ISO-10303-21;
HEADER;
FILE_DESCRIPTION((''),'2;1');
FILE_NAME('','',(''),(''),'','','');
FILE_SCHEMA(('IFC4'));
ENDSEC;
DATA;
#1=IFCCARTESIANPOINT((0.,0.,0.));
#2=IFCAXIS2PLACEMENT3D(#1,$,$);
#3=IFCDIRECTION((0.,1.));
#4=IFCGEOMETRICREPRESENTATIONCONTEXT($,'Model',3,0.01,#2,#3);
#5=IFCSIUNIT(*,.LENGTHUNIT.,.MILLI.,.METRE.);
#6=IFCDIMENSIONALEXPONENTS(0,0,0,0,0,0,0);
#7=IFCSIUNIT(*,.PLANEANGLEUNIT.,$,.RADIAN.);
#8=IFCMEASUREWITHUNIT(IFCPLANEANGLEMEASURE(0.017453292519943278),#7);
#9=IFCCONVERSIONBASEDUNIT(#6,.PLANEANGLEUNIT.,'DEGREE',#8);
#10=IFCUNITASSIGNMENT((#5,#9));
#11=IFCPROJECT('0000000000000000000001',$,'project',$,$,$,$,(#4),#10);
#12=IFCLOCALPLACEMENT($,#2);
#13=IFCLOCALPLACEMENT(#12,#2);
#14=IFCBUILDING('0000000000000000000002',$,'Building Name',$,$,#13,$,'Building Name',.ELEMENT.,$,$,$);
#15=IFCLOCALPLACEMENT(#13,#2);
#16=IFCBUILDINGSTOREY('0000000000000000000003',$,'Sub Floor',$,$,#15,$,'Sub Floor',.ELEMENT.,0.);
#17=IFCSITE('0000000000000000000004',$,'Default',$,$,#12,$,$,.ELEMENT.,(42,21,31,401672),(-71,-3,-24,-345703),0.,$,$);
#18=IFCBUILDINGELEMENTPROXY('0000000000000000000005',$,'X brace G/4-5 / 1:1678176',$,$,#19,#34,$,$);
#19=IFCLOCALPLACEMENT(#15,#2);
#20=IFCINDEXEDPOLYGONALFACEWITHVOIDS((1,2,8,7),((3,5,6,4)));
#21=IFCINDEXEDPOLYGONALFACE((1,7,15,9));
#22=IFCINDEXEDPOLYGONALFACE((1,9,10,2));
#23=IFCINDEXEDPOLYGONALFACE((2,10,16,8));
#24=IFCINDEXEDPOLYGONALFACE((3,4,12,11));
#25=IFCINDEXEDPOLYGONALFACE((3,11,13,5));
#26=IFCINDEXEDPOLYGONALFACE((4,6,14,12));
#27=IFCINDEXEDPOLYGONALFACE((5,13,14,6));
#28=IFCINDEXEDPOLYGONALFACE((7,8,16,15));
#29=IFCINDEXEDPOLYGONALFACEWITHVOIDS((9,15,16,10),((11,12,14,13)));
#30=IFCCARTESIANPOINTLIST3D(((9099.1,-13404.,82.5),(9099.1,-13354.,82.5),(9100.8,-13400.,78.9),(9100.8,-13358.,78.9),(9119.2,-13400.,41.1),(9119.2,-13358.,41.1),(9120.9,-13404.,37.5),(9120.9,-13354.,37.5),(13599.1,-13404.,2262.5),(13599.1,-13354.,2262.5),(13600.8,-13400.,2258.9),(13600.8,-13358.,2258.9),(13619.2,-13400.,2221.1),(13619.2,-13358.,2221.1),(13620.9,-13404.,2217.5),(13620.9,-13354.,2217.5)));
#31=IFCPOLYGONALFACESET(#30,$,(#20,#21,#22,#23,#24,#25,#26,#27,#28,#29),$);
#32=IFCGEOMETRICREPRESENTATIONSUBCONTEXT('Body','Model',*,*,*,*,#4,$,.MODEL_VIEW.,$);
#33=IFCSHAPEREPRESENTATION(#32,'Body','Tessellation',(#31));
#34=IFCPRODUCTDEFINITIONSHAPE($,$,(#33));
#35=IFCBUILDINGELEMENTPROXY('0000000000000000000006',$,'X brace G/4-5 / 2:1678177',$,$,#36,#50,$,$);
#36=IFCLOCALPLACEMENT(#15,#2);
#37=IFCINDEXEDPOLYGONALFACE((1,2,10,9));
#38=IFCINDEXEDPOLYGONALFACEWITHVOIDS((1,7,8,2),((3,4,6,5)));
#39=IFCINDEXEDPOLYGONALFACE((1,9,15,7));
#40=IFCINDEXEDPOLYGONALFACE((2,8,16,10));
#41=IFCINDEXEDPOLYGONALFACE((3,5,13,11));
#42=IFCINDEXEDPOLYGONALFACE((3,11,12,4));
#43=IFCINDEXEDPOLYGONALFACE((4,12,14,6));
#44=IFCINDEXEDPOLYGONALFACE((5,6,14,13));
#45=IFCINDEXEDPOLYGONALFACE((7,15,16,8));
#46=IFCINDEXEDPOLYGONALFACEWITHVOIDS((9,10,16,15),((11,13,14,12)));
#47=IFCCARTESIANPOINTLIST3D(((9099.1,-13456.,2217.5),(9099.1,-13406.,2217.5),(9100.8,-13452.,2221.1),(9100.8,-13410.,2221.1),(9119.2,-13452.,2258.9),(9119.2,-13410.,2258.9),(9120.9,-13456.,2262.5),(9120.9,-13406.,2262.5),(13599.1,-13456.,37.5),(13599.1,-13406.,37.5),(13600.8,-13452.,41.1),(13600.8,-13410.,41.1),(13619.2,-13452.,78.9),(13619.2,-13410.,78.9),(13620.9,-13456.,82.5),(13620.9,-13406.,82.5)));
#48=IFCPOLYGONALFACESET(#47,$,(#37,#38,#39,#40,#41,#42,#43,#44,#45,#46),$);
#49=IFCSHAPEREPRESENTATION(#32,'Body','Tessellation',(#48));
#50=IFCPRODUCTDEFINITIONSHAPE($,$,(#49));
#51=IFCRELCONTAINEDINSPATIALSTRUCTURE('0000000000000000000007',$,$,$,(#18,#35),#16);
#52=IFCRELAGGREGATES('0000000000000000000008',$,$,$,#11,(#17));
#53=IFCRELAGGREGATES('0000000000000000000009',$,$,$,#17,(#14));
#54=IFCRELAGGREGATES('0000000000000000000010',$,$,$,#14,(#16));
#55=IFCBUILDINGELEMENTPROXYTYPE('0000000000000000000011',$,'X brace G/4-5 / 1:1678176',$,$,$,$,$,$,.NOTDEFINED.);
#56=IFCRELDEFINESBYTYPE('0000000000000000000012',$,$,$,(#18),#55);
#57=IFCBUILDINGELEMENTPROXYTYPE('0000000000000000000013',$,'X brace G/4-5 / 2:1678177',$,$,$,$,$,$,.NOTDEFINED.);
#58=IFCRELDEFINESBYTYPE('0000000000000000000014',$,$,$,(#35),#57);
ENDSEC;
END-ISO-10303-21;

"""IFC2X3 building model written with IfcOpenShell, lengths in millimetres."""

from ifc_helpers import new_model, entity, si_unit, converted_unit, direction, frame, origin, place, context, subcontext, project, spatial, polyline, outline, extrude, type_object, element, save


model = new_model("IFC2X3")

# Units and contexts
model_context = context("Model", 3, precision=0.01, world=origin(), true_north=direction((0.0, 1.0)))
body_context = subcontext(model_context, "Body", "Model", "MODEL_VIEW")
ifc_project = project(units=[si_unit("LENGTHUNIT", "METRE", prefix="MILLI"), converted_unit("PLANEANGLEUNIT", "DEGREE", entity("IfcPlaneAngleMeasure", 0.017453292519943278), si_unit("PLANEANGLEUNIT", "RADIAN"), dimensions=[0, 0, 0, 0, 0, 0, 0])], contexts=[model_context])

# Site, building, storey
site_placement = place(None, origin())
site = spatial("IfcSite", under=ifc_project, at=site_placement, Name="Default", CompositionType="ELEMENT", RefLatitude=(42, 21, 31, 401672), RefLongitude=(-71, -3, -24, -345703), RefElevation=0.0)
building_placement = place(site_placement, origin())
building = spatial("IfcBuilding", under=site, at=building_placement, Name="Building Name", LongName="Building Name", CompositionType="ELEMENT")
storey_placement = place(building_placement, origin())
storey = spatial("IfcBuildingStorey", under=building, at=storey_placement, Name="Sub Floor", LongName="Sub Floor", CompositionType="ELEMENT", Elevation=0.0)

# Building element proxies
building_element_proxy_type_1 = type_object("IfcBuildingElementProxyType", Name="X brace G/4-5 / 1:1678176", PredefinedType="NOTDEFINED")
proxy_1_placement = place(storey_placement, origin())
element("IfcBuildingElementProxy", 1, at=proxy_1_placement, inside=storey, type_object=building_element_proxy_type_1, Name="X brace G/4-5 / 1:1678176", context=body_context, shape_type="SweptSolid", body=[
    extrude(outline(polyline([(-25.0, -25.0), (25.0, -25.0), (25.0, 25.0), (-25.0, 25.0), (-25.0, -25.0)]), holes=[polyline([(-21.0, -21.0), (-21.0, 21.0), (21.0, 21.0), (21.0, -21.0), (-21.0, -21.0)])]), frame((9110.0, -13379.0, 60.0), z_axis=(0.899957, 0.0, 0.435979), x_axis=(0.0, -1.0, 0.0)), (0.0, 0.0, 1.0), 5000.2),
])
building_element_proxy_type_2 = type_object("IfcBuildingElementProxyType", Name="X brace G/4-5 / 2:1678177", PredefinedType="NOTDEFINED")
proxy_2_placement = place(storey_placement, origin())
element("IfcBuildingElementProxy", 2, at=proxy_2_placement, inside=storey, type_object=building_element_proxy_type_2, Name="X brace G/4-5 / 2:1678177", context=body_context, shape_type="SweptSolid", body=[
    extrude(outline(polyline([(-25.0, -25.0), (25.0, -25.0), (25.0, 25.0), (-25.0, 25.0), (-25.0, -25.0)]), holes=[polyline([(-21.0, -21.0), (-21.0, 21.0), (21.0, 21.0), (21.0, -21.0), (-21.0, -21.0)])]), frame((9110.0, -13431.0, 2240.0), z_axis=(0.899957, 0.0, -0.435979), x_axis=(-0.435979, 0.0, -0.899957)), (0.0, 0.0, 1.0), 5000.2),
])

save(model, "model.ifc")
